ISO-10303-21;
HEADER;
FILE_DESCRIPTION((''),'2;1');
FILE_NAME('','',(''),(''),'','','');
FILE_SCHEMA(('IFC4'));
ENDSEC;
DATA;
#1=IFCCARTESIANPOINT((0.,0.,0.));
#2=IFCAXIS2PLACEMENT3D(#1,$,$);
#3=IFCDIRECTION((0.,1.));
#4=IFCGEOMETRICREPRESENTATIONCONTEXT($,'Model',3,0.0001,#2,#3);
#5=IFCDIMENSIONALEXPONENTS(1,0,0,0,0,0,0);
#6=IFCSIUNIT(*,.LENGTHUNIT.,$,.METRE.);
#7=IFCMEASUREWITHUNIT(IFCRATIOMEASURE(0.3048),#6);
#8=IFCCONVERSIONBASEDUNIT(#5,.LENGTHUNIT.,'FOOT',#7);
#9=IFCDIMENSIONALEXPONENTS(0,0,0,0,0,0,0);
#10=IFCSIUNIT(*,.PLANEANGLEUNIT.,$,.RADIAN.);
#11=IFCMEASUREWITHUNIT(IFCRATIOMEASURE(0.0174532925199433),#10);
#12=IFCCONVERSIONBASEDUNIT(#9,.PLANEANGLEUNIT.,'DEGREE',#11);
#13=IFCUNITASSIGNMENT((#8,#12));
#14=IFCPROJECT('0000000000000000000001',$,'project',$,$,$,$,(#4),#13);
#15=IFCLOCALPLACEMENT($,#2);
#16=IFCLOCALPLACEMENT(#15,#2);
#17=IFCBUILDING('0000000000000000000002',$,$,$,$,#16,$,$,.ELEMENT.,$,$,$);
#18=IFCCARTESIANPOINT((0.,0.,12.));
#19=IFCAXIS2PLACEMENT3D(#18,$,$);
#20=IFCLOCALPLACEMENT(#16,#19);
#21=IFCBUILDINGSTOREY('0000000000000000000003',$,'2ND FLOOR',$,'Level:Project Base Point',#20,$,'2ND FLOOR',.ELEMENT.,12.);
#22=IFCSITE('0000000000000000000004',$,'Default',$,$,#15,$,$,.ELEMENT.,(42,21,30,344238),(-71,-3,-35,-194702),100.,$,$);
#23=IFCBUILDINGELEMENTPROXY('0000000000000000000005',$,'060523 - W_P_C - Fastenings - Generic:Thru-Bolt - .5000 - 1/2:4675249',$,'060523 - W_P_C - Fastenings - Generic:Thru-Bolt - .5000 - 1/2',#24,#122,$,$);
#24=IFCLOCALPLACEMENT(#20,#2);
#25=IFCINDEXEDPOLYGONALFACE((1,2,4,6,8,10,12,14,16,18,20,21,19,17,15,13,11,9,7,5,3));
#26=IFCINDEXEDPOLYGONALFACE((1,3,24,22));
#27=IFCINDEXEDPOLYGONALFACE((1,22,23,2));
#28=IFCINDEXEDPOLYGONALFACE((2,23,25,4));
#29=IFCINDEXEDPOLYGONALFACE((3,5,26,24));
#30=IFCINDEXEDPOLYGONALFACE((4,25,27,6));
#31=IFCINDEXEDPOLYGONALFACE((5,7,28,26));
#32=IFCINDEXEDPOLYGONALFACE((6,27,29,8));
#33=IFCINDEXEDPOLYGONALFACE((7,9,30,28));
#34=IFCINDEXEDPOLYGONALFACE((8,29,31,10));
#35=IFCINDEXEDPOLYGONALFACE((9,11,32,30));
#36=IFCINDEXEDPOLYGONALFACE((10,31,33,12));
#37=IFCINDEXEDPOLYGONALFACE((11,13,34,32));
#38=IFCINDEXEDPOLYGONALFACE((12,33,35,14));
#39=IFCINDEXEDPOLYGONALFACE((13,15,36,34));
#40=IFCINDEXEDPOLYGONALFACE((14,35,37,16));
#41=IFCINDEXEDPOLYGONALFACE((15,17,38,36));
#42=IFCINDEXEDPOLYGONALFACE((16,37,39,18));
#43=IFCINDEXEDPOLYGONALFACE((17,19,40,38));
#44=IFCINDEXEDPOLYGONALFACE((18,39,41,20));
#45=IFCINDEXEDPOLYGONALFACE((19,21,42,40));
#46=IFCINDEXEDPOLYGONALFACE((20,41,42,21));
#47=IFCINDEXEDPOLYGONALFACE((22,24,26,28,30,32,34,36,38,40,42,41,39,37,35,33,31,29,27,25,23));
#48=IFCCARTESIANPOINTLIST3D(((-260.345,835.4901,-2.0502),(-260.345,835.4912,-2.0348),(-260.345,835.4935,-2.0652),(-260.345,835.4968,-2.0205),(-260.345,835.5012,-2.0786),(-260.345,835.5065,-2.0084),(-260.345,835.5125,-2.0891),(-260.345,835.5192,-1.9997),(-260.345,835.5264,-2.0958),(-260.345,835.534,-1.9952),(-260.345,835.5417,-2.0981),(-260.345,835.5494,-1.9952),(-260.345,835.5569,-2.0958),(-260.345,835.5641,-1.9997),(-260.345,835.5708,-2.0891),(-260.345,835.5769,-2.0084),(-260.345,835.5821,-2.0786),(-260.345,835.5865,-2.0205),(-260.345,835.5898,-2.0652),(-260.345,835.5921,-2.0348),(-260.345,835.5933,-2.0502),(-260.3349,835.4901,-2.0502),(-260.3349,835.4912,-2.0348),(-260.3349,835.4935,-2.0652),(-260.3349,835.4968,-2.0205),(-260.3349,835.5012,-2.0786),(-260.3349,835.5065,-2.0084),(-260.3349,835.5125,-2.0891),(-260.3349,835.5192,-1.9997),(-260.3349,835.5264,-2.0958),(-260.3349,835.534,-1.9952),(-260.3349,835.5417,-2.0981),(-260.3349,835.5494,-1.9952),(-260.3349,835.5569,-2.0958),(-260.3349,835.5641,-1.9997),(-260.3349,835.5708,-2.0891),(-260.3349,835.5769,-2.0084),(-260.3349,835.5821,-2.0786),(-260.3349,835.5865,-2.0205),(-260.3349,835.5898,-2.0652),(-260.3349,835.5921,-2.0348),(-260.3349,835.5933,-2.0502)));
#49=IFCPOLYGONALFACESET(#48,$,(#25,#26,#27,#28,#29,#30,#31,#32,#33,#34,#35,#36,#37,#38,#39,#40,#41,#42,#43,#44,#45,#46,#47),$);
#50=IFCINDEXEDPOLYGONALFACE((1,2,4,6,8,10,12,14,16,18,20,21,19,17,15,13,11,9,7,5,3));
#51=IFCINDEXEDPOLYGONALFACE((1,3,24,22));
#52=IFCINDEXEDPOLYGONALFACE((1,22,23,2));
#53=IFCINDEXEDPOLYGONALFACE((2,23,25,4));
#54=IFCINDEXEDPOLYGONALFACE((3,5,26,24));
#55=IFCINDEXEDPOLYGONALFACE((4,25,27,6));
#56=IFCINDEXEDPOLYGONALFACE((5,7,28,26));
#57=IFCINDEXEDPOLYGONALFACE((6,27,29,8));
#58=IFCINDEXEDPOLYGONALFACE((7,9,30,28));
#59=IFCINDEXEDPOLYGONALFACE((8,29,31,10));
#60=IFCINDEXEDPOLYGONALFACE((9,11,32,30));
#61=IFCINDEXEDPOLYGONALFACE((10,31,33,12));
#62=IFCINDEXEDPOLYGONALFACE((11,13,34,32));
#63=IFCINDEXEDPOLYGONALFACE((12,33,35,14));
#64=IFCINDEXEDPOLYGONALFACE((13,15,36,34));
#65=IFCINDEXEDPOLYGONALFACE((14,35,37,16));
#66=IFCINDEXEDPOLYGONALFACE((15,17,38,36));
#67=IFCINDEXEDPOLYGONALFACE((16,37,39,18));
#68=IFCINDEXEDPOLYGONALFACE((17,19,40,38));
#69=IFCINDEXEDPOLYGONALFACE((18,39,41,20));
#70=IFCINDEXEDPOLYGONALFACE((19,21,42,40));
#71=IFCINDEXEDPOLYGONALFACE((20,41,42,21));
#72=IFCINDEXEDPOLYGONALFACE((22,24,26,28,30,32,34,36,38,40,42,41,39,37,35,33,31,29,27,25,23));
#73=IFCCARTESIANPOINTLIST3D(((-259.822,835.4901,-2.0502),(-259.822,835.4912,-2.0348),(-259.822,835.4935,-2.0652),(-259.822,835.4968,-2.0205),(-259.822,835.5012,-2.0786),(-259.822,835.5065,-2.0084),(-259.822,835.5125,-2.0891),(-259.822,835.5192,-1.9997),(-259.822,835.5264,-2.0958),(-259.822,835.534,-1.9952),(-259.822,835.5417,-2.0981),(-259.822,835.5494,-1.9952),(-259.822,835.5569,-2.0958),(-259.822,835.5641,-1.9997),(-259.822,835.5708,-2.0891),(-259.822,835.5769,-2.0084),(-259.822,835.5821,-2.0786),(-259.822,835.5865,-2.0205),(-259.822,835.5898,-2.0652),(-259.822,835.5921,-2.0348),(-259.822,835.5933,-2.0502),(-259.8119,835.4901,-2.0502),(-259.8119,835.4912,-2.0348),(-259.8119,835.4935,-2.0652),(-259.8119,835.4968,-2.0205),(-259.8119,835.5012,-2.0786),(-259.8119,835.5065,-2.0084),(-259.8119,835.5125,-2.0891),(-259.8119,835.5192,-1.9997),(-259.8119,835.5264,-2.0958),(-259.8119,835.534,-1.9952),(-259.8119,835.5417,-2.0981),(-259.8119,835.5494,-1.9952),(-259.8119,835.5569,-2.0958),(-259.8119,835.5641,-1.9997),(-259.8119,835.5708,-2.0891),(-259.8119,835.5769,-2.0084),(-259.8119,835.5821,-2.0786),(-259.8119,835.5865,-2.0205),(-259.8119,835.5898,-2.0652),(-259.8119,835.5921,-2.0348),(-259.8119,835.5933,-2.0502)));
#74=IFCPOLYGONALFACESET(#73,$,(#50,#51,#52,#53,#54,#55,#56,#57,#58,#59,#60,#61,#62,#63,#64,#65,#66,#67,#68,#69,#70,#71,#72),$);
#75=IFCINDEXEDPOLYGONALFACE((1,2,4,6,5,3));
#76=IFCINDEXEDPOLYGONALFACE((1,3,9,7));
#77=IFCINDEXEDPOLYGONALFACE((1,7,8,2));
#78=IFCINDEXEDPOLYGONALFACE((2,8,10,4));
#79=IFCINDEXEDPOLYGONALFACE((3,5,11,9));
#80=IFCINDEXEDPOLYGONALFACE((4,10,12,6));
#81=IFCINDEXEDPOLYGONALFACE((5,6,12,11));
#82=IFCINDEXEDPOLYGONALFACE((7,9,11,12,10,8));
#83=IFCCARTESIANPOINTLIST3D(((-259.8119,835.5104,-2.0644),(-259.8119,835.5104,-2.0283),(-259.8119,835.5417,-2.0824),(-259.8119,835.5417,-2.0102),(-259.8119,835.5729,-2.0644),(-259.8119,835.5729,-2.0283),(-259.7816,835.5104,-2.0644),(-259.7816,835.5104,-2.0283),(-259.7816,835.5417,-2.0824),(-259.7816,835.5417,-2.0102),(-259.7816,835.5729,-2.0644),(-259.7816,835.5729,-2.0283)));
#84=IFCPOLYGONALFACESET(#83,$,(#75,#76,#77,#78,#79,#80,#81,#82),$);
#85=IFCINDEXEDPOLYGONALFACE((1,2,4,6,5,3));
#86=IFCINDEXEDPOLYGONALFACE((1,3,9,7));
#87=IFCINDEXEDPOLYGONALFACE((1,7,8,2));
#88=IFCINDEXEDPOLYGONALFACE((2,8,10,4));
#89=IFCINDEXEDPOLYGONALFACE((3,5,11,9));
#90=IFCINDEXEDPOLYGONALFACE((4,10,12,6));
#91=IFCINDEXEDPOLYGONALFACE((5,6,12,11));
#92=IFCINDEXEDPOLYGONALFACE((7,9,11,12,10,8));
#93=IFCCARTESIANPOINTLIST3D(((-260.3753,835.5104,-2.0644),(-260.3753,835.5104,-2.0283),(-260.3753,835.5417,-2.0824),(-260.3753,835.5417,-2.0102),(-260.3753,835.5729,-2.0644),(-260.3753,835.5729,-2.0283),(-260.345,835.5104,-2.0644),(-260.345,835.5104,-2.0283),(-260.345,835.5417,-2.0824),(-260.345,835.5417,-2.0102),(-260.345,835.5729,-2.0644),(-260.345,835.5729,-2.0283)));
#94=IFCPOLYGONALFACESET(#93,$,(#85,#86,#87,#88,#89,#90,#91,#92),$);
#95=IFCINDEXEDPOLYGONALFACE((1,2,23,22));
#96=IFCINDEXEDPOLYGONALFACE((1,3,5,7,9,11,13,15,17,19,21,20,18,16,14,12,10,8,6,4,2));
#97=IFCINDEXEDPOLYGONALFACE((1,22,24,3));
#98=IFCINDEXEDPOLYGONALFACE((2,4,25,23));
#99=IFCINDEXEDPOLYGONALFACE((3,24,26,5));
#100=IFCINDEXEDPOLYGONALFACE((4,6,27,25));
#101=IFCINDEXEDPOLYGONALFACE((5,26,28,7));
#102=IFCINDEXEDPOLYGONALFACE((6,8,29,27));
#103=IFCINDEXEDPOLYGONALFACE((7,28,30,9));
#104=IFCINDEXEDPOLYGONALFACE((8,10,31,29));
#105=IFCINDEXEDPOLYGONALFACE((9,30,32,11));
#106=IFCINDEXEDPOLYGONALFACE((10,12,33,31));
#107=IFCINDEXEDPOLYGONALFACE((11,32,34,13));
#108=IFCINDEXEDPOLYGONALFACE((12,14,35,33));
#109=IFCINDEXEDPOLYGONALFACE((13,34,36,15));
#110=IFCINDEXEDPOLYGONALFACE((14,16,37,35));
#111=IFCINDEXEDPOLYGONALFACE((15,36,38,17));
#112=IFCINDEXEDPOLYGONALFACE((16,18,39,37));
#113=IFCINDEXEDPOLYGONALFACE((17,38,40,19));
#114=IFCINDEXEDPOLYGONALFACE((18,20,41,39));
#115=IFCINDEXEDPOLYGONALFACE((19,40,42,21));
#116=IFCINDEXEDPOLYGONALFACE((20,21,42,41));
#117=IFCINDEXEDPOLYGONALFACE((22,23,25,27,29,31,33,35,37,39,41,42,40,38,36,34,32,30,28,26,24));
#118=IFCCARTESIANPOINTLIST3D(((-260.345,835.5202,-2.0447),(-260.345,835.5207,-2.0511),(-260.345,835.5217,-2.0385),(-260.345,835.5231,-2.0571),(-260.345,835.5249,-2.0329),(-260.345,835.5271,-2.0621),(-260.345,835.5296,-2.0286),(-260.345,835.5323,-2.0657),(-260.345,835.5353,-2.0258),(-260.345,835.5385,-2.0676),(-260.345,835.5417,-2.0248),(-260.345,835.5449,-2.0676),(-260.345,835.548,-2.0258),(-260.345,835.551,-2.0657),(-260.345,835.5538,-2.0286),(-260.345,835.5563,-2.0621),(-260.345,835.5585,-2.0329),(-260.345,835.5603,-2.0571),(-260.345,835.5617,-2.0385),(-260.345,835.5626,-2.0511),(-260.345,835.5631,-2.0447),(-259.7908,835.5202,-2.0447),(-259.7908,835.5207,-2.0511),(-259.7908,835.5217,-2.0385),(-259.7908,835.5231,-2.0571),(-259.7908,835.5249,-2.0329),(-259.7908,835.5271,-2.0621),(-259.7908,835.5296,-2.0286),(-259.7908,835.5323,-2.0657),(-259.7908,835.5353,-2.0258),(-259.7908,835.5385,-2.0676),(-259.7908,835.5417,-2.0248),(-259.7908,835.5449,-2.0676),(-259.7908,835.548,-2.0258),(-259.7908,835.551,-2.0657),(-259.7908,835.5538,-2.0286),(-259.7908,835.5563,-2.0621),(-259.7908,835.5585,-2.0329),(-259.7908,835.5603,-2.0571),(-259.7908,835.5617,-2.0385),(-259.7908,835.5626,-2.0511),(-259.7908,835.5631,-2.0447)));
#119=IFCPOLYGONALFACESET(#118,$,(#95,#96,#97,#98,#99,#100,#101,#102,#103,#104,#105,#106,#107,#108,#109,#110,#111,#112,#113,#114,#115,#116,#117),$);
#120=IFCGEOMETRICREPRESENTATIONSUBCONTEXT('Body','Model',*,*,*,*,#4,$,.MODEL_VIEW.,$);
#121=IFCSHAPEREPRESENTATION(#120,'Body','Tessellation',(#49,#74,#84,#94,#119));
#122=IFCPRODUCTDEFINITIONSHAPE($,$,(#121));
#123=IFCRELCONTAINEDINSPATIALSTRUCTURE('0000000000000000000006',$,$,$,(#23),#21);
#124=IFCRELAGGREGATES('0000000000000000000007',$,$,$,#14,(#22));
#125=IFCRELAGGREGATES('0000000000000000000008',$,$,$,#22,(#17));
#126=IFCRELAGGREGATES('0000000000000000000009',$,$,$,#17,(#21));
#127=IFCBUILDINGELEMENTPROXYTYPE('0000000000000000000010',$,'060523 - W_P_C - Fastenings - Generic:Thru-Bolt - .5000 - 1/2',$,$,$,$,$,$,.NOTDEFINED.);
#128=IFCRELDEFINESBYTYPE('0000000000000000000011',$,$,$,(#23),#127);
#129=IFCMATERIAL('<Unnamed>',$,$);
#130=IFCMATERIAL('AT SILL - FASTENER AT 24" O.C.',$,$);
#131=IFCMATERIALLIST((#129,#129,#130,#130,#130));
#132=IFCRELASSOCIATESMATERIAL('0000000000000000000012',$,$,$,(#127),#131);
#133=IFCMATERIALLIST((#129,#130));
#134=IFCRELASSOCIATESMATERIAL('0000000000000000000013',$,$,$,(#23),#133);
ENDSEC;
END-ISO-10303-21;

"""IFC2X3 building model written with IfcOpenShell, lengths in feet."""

from ifc_helpers import new_model, entity, si_unit, converted_unit, direction, frame, frame_2d, origin, place, context, subcontext, project, spatial, polyline, circle, outline, extrude, source, transform, mapped, material, material_list, type_object, type_shapes, element, save


model = new_model("IFC2X3")

# Units and contexts
model_context = context("Model", 3, precision=0.0001, world=origin(), true_north=direction((0.0, 1.0)))
body_context = subcontext(model_context, "Body", "Model", "MODEL_VIEW")
ifc_project = project(units=[converted_unit("LENGTHUNIT", "FOOT", entity("IfcRatioMeasure", 0.3048), si_unit("LENGTHUNIT", "METRE"), dimensions=[1, 0, 0, 0, 0, 0, 0]), converted_unit("PLANEANGLEUNIT", "DEGREE", entity("IfcRatioMeasure", 0.0174532925199433), si_unit("PLANEANGLEUNIT", "RADIAN"), dimensions=[0, 0, 0, 0, 0, 0, 0])], contexts=[model_context])

# Site, building, storey
site_placement = place(None, origin())
site = spatial("IfcSite", under=ifc_project, at=site_placement, Name="Default", CompositionType="ELEMENT", RefLatitude=(42, 21, 30, 344238), RefLongitude=(-71, -3, -35, -194702), RefElevation=100.0)
building_placement = place(site_placement, origin())
building = spatial("IfcBuilding", under=site, at=building_placement, CompositionType="ELEMENT")
storey_placement = place(building_placement, frame((0.0, 0.0, 12.0)))
storey = spatial("IfcBuildingStorey", under=building, at=storey_placement, Name="2ND FLOOR", ObjectType="Level:Project Base Point", LongName="2ND FLOOR", CompositionType="ELEMENT", Elevation=12.0)

# Building element proxy
ifc_material_1 = material(Name="<Unnamed>")
ifc_material_2 = material(Name="AT SILL - FASTENER AT 24\" O.C.")
ifc_material_list_1 = material_list([ifc_material_1, ifc_material_1, ifc_material_2, ifc_material_2, ifc_material_2])
building_element_proxy_type_1 = type_object("IfcBuildingElementProxyType", Name="060523 - W_P_C - Fastenings - Generic:Thru-Bolt - .5000 - 1/2", PredefinedType="NOTDEFINED", material=ifc_material_list_1)
shared_shape_1 = source(origin(), body_context, "Body", "SweptSolid", [
    extrude(circle(Radius=0.0518, at=frame_2d((0.0, 0.0), x_axis=(1.0, 0.0))), frame((0.0, 0.0, 0.0), z_axis=(0.0, 0.0, 1.0), x_axis=(0.0, 1.0, 0.0)), (0.0, 0.0, 1.0), 0.0101),
    extrude(circle(Radius=0.0518, at=frame_2d((0.0, 0.0), x_axis=(1.0, 0.0))), frame((0.0, 0.0, -0.523), z_axis=(0.0, 0.0, 1.0), x_axis=(0.0, 1.0, 0.0)), (0.0, 0.0, 1.0), 0.0101),
    extrude(outline(polyline([(-0.018, -0.0313), (0.018, -0.0313), (0.0361, 0.0), (0.018, 0.0313), (-0.018, 0.0313), (-0.0361, 0.0), (-0.018, -0.0313)])), frame((0.0, 0.0, -0.5533), z_axis=(0.0, 0.0, 1.0), x_axis=(0.0, -1.0, 0.0)), (0.0, 0.0, 1.0), 0.0303),
    extrude(outline(polyline([(-0.018, -0.0313), (0.018, -0.0313), (0.0361, 0.0), (0.018, 0.0312), (-0.018, 0.0312), (-0.0361, 0.0), (-0.018, -0.0313)])), frame((0.0, 0.0, 0.0101), z_axis=(0.0, 0.0, 1.0), x_axis=(0.866025, -0.5, 0.0)), (0.0, 0.0, 1.0), 0.0303),
    extrude(circle(Radius=0.0215, at=frame_2d((0.0, 0.0), x_axis=(1.0, 0.0))), frame((0.0, 0.0, -0.5442), z_axis=(0.0, 0.0, 1.0), x_axis=(0.0, -1.0, 0.0)), (0.0, 0.0, 1.0), 0.5543),
])
type_shapes(building_element_proxy_type_1, [shared_shape_1])
ifc_material_list_2 = material_list([ifc_material_1, ifc_material_2])
proxy_1_placement = place(storey_placement, frame((-260.3349, 835.5417, -2.0463), z_axis=(-1.0, 0.0, 0.0), x_axis=(0.0, 1.0, 0.0)))
element("IfcBuildingElementProxy", 1, at=proxy_1_placement, inside=storey, type_object=building_element_proxy_type_1, material=ifc_material_list_2, Name="060523 - W_P_C - Fastenings - Generic:Thru-Bolt - .5000 - 1/2:4675249", ObjectType="060523 - W_P_C - Fastenings - Generic:Thru-Bolt - .5000 - 1/2", context=body_context, shape_type="MappedRepresentation", body=[
    mapped(shared_shape_1, transform((0.0, 0.0, 0.0), scale=1.0)),
])

save(model, "model.ifc")
